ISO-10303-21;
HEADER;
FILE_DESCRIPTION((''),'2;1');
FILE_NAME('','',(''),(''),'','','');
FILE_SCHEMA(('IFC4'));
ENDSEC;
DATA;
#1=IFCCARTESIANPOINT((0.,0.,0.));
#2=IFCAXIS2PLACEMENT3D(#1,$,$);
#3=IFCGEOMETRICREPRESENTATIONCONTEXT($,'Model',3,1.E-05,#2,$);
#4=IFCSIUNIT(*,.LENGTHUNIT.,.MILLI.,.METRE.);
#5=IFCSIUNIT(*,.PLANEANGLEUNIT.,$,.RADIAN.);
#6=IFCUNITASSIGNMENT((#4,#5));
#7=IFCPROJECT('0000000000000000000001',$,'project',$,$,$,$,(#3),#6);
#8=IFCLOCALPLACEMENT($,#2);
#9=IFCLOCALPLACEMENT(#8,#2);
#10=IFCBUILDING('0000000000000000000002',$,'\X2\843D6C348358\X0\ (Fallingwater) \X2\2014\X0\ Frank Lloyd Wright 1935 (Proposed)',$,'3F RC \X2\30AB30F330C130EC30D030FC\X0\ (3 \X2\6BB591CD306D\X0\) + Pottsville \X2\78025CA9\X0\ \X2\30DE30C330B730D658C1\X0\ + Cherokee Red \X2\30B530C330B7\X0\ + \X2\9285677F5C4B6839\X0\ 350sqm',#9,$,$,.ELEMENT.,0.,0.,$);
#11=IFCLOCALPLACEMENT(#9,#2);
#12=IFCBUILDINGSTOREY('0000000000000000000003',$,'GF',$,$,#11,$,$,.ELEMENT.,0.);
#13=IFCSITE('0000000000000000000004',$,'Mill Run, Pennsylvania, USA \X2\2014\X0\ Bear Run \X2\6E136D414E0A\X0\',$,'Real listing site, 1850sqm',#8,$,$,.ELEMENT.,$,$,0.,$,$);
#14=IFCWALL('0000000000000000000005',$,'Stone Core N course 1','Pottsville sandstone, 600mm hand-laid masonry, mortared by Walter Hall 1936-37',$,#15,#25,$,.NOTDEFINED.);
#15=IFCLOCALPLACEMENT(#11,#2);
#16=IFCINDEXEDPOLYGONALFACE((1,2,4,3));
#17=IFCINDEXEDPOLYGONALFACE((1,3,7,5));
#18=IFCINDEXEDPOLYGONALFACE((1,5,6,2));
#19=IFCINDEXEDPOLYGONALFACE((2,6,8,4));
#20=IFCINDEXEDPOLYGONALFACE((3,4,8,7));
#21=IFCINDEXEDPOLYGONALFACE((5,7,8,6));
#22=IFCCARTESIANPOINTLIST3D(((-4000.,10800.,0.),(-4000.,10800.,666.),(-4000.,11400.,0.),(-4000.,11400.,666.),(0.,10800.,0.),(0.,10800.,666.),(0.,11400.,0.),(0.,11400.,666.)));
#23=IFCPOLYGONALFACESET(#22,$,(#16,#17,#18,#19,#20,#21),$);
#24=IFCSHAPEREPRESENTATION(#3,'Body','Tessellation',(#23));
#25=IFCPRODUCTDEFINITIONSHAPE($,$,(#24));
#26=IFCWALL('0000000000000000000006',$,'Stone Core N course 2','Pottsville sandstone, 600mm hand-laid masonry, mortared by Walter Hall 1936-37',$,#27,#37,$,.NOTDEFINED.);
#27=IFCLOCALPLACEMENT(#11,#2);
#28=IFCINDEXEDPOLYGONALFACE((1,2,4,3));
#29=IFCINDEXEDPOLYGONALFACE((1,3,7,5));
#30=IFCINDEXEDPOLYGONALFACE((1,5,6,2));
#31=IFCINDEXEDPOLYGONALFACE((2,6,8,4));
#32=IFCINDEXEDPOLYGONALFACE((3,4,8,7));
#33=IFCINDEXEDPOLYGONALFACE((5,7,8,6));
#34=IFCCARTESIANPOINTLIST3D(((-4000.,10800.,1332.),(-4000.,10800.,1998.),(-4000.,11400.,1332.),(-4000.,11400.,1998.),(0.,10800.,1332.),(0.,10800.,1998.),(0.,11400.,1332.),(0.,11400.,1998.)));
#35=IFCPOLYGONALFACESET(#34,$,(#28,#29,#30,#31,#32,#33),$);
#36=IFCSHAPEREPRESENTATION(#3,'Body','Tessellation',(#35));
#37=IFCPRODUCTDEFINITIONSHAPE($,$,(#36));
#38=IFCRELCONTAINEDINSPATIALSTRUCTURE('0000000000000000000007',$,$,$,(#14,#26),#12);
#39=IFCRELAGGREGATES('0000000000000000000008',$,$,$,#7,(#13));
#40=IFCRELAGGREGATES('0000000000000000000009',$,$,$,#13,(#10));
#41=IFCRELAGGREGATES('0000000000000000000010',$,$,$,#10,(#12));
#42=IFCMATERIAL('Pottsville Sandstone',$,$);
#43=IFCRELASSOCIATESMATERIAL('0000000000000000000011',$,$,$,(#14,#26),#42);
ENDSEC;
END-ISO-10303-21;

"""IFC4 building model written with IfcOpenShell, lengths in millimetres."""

from ifc_helpers import new_model, si_unit, frame, frame_2d, origin, place, context, project, spatial, rectangle, extrude, material, element, save


model = new_model("IFC4")

# Units and contexts
model_context = context("Model", 3, precision=1e-05, world=origin())
ifc_project = project(units=[si_unit("LENGTHUNIT", "METRE", prefix="MILLI"), si_unit("PLANEANGLEUNIT", "RADIAN")], contexts=[model_context])

# Site, building, storey
site_placement = place(None, origin())
site = spatial("IfcSite", under=ifc_project, at=site_placement, Name="Mill Run, Pennsylvania, USA — Bear Run 渓流上", ObjectType="Real listing site, 1850sqm", CompositionType="ELEMENT", RefElevation=0.0)
building_placement = place(site_placement, origin())
building = spatial("IfcBuilding", under=site, at=building_placement, Name="落水荘 (Fallingwater) — Frank Lloyd Wright 1935 (Proposed)", ObjectType="3F RC カンチレバー (3 段重ね) + Pottsville 砂岩 マッシブ壁 + Cherokee Red サッシ + 銅板屋根 350sqm", CompositionType="ELEMENT", ElevationOfRefHeight=0.0, ElevationOfTerrain=0.0)
storey_placement = place(building_placement, origin())
storey = spatial("IfcBuildingStorey", under=building, at=storey_placement, Name="GF", CompositionType="ELEMENT", Elevation=0.0)

# Walls
ifc_material_1 = material(Name="Pottsville Sandstone")
wall_1_placement = place(storey_placement, frame((-2000.0, 5400.0, 0.0)))
element("IfcWall", 1, at=wall_1_placement, inside=storey, material=ifc_material_1, Name="Stone Core N course 1", Description="Pottsville sandstone, 600mm hand-laid masonry, mortared by Walter Hall 1936-37", PredefinedType="NOTDEFINED", context=model_context, shape_type="SweptSolid", body=[
    extrude(rectangle(XDim=4000.0, YDim=600.0, at=frame_2d((2000.0, 300.0))), frame((-2000.0, 5400.0, 0.0)), (0.0, 0.0, 1.0), 666.0),
])
wall_2_placement = place(storey_placement, frame((-2000.0, 5400.0, 666.0)))
element("IfcWall", 2, at=wall_2_placement, inside=storey, material=ifc_material_1, Name="Stone Core N course 2", Description="Pottsville sandstone, 600mm hand-laid masonry, mortared by Walter Hall 1936-37", PredefinedType="NOTDEFINED", context=model_context, shape_type="SweptSolid", body=[
    extrude(rectangle(XDim=4000.0, YDim=600.0, at=frame_2d((2000.0, 300.0))), frame((-2000.0, 5400.0, 666.0)), (0.0, 0.0, 1.0), 666.0),
])

save(model, "model.ifc")
